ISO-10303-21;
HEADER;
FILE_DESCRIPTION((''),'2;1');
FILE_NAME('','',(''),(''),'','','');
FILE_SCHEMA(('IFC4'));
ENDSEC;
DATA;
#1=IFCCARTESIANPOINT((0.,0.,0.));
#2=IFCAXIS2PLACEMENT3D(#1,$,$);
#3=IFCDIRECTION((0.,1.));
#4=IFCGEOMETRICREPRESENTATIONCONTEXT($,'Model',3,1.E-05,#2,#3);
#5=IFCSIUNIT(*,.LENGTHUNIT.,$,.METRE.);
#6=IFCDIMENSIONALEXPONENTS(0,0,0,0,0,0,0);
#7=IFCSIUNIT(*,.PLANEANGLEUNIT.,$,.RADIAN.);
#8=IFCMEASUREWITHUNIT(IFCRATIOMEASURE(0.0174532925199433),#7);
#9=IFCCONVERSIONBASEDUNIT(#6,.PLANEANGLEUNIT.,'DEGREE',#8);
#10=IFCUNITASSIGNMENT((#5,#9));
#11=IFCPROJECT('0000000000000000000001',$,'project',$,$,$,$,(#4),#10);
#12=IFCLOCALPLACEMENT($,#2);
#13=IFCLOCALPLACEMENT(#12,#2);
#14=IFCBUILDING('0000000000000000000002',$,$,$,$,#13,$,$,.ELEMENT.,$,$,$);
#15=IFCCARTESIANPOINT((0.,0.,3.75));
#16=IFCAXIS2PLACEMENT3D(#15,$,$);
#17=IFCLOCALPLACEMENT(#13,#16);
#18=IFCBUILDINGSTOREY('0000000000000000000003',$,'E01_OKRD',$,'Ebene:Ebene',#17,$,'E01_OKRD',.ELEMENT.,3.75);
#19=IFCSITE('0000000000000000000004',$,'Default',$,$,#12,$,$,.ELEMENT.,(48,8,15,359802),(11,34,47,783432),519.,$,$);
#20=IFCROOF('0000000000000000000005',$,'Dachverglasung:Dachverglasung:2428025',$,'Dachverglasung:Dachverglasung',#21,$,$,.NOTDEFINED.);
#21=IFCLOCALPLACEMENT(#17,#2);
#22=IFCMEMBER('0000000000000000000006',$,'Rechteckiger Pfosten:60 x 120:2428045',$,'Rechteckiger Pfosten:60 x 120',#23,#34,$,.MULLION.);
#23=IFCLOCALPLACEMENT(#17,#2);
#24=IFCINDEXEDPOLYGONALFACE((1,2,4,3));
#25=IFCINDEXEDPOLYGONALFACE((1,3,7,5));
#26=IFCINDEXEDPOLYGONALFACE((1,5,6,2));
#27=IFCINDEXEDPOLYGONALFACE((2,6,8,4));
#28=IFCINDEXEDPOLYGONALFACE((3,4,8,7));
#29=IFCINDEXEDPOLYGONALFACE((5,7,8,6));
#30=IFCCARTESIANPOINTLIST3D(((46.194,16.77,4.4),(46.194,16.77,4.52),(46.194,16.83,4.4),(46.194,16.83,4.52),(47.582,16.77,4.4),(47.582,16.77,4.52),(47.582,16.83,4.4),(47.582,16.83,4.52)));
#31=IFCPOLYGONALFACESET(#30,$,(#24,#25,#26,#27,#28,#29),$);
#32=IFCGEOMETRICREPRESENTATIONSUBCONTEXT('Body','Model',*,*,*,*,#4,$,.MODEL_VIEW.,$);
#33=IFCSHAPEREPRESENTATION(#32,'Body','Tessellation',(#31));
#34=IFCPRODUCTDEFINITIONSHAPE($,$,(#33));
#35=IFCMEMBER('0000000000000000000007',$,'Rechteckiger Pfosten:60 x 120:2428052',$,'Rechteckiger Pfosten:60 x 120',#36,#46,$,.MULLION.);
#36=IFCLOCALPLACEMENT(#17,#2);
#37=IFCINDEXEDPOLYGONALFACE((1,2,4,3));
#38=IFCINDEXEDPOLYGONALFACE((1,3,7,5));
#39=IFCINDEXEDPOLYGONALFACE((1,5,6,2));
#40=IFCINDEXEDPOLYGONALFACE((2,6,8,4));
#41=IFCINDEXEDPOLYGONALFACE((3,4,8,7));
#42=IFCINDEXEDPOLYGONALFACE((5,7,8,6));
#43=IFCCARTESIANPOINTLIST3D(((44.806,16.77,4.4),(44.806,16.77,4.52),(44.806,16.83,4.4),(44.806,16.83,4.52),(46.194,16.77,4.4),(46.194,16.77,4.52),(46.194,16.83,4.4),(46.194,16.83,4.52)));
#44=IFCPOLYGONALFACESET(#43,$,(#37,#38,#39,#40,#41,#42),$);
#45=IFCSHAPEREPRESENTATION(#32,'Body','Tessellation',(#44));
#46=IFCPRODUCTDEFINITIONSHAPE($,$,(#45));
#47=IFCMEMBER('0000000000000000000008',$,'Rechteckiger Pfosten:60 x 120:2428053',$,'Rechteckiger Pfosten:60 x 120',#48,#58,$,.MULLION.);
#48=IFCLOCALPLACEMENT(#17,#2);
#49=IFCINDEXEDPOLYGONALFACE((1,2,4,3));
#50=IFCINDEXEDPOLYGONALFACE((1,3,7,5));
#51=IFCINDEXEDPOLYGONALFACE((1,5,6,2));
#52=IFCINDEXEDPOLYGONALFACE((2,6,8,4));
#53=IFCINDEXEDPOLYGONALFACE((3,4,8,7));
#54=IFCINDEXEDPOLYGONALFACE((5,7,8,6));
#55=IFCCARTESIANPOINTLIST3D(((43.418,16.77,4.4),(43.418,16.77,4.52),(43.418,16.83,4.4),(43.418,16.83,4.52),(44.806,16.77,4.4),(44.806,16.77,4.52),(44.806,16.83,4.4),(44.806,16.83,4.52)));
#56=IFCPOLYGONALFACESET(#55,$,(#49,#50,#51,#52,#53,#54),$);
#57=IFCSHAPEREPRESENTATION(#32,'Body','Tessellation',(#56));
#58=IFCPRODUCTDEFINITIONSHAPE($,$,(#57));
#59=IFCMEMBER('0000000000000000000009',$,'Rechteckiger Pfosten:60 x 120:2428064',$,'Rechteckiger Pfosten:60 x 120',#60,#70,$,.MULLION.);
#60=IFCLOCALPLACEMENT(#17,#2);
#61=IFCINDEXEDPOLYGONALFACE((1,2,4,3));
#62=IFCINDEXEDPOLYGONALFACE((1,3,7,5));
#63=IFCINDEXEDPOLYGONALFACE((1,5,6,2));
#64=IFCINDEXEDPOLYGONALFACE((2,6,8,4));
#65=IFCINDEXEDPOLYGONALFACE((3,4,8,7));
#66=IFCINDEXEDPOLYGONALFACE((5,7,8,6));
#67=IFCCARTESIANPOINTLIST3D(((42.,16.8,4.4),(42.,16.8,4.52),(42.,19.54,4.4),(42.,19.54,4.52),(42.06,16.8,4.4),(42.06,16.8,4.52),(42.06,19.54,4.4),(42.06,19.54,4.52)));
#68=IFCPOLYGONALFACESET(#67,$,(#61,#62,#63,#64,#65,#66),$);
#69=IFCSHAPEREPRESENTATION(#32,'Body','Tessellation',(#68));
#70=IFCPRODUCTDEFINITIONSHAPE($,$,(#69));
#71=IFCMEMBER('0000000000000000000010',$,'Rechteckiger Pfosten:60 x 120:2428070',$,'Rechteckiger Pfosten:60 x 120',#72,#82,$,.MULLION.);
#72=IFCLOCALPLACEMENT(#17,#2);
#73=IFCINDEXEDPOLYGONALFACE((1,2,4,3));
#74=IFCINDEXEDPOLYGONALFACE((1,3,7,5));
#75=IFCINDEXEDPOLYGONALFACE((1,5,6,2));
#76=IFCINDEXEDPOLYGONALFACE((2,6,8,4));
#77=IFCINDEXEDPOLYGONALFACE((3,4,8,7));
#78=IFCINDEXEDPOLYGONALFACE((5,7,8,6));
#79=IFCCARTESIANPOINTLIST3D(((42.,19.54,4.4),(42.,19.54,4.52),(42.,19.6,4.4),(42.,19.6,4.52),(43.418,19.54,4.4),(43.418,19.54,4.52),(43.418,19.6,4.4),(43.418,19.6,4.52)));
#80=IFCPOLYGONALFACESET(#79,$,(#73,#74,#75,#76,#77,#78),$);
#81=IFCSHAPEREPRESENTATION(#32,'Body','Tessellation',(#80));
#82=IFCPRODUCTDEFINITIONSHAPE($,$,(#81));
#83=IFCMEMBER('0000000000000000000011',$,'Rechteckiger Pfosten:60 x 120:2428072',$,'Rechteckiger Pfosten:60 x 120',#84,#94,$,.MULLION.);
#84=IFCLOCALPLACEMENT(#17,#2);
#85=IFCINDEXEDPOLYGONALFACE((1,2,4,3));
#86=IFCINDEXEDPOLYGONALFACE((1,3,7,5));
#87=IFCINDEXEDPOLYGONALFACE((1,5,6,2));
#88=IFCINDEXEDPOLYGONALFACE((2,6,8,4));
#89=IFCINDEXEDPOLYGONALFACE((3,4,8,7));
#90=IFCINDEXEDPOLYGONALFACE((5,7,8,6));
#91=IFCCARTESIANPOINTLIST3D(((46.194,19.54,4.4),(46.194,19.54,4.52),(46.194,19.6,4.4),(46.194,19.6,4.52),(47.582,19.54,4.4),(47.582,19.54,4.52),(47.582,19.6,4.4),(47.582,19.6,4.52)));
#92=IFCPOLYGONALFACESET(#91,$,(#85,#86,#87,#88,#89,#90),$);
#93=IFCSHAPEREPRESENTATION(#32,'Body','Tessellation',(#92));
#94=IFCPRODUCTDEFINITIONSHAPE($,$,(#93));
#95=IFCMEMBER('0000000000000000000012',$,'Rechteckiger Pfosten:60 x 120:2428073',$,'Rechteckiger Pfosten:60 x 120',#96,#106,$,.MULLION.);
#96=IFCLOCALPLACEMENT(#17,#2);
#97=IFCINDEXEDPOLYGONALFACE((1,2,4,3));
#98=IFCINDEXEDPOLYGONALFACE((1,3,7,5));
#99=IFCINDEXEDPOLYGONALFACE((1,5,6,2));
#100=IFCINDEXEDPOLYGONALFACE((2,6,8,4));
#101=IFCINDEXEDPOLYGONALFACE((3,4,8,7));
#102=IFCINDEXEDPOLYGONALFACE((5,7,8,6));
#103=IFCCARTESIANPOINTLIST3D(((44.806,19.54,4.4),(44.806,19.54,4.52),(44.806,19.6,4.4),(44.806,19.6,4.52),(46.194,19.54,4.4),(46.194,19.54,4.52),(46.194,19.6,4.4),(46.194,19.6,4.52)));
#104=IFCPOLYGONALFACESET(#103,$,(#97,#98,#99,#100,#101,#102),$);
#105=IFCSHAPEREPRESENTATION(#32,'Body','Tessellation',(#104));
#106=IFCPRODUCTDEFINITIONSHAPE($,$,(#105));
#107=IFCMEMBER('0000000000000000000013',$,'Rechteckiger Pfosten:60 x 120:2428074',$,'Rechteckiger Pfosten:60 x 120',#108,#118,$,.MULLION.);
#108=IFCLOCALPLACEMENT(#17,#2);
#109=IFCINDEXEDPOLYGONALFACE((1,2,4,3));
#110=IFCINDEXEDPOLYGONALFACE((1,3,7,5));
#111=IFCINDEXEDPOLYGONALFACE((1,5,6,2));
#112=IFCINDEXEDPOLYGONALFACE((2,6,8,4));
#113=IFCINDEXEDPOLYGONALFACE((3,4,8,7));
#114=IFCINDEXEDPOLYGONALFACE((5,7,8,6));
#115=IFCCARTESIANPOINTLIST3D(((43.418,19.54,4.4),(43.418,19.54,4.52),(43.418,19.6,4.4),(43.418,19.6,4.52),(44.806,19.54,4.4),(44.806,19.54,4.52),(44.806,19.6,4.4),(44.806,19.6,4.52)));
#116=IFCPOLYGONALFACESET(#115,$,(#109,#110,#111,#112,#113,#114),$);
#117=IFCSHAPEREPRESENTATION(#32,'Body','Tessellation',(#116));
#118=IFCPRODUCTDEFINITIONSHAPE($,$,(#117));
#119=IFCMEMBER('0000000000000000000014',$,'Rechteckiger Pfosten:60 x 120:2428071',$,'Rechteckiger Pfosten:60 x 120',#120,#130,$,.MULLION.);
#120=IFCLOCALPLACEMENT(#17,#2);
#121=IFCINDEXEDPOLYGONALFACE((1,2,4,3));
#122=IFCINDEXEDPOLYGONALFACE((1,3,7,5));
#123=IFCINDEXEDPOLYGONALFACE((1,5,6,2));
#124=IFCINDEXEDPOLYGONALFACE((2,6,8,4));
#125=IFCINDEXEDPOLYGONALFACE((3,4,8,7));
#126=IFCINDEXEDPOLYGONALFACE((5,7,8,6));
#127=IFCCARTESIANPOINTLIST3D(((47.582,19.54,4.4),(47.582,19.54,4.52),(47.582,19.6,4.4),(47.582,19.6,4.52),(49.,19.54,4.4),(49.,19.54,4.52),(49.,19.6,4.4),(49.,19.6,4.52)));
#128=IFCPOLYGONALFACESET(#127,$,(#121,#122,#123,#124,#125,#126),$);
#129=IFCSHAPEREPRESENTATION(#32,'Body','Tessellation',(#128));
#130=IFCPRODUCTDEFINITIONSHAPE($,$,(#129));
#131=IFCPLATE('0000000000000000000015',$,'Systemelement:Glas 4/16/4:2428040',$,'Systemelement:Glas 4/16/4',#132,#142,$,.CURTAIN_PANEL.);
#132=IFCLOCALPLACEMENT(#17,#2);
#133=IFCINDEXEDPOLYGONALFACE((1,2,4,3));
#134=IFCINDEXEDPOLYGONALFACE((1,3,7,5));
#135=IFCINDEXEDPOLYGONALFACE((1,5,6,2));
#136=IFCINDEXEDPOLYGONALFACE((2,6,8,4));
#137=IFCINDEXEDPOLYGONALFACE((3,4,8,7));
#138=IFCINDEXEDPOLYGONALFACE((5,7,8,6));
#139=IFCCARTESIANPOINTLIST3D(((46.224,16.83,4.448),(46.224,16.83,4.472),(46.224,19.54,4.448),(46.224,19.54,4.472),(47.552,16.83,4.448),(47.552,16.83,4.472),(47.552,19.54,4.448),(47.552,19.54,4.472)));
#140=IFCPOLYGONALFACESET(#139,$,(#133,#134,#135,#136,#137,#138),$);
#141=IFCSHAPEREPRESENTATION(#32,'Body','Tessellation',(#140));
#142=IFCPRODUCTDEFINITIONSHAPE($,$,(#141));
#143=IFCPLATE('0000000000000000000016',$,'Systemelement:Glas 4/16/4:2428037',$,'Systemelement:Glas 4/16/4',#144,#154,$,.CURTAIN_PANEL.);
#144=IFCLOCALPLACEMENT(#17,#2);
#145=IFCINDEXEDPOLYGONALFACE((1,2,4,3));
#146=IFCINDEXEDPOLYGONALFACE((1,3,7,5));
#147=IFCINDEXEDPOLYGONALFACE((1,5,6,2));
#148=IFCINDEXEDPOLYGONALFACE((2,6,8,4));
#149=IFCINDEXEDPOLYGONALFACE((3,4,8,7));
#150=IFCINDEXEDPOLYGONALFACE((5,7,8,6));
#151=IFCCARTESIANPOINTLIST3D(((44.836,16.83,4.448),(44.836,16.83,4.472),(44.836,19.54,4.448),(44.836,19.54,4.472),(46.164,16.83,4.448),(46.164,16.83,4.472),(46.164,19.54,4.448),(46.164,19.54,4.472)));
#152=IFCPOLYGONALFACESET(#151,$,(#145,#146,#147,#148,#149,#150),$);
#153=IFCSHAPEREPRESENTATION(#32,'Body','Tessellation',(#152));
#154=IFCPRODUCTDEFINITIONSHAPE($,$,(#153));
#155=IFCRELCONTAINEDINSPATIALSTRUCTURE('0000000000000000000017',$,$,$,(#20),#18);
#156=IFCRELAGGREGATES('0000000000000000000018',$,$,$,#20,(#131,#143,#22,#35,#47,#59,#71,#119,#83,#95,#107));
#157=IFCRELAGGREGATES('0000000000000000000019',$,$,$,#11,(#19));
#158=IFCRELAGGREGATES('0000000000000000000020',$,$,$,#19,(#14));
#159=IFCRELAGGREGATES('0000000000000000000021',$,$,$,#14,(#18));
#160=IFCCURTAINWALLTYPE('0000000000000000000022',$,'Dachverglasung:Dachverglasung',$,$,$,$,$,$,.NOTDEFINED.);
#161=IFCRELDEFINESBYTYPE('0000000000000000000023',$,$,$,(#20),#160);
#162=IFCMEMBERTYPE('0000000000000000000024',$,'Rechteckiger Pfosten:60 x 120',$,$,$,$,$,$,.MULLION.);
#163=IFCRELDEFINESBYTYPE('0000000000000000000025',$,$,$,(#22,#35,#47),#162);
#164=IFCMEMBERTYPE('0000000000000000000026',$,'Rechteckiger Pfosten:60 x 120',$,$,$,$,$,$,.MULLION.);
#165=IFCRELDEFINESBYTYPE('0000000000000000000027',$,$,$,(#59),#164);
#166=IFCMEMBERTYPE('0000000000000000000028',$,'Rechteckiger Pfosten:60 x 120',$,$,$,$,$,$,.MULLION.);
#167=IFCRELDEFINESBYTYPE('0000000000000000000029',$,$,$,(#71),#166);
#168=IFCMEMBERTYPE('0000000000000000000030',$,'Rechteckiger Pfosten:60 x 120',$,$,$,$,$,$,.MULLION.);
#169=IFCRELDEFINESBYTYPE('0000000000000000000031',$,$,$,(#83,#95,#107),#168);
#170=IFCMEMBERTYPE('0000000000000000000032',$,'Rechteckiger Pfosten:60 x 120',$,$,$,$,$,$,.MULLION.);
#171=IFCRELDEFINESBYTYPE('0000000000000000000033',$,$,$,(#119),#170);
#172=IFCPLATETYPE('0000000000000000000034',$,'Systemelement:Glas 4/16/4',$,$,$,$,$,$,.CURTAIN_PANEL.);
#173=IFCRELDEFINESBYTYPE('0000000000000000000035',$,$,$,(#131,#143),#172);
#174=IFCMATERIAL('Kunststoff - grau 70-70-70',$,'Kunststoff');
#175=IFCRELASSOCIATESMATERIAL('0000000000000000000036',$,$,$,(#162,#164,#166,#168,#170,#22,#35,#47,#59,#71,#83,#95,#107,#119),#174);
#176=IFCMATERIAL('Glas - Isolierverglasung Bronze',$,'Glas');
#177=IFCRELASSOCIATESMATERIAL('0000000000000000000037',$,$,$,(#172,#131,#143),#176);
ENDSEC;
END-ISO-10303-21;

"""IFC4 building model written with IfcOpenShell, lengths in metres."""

from ifc_helpers import new_model, entity, si_unit, converted_unit, direction, frame, frame_2d, origin, origin_2d_with_axis, place, context, subcontext, project, spatial, rectangle, extrude, shape, source, transform, mapped, material, material_profile, profile_set, profile_usage, type_object, type_shapes, element, aggregate, save


model = new_model("IFC4")

# Units and contexts
model_context = context("Model", 3, precision=1e-05, world=origin(), true_north=direction((0.0, 1.0)))
body_context = subcontext(model_context, "Body", "Model", "MODEL_VIEW")
footprint_context = subcontext(model_context, "FootPrint", "Model", "MODEL_VIEW")
ifc_project = project(units=[si_unit("LENGTHUNIT", "METRE"), converted_unit("PLANEANGLEUNIT", "DEGREE", entity("IfcRatioMeasure", 0.0174532925199433), si_unit("PLANEANGLEUNIT", "RADIAN"), dimensions=[0, 0, 0, 0, 0, 0, 0])], contexts=[model_context])

# Site, building, storey
site_placement = place(None, frame((0.0, 0.0, 0.0)))
site = spatial("IfcSite", under=ifc_project, at=site_placement, Name="Default", CompositionType="ELEMENT", RefLatitude=(48, 8, 15, 359802), RefLongitude=(11, 34, 47, 783432), RefElevation=519.0)
building_placement = place(site_placement, origin())
building = spatial("IfcBuilding", under=site, at=building_placement, CompositionType="ELEMENT")
storey_placement = place(building_placement, frame((0.0, 0.0, 3.75)))
storey = spatial("IfcBuildingStorey", under=building, at=storey_placement, Name="E01_OKRD", ObjectType="Ebene:Ebene", LongName="E01_OKRD", CompositionType="ELEMENT", Elevation=3.75)

# Roof, members, plates
curtain_wall_type = type_object("IfcCurtainWallType", Name="Dachverglasung:Dachverglasung", PredefinedType="NOTDEFINED")
roof_placement = place(storey_placement, frame((0.0, 0.0, -3.75)))
roof = element("IfcRoof", 1, at=roof_placement, inside=storey, type_object=curtain_wall_type, Name="Dachverglasung:Dachverglasung:2428025", ObjectType="Dachverglasung:Dachverglasung", PredefinedType="NOTDEFINED")
ifc_material_1 = material(Name="Kunststoff - grau 70-70-70", Category="Kunststoff")
ifc_material_profile_1 = material_profile(ifc_material_1, rectangle(XDim=0.06, YDim=0.12, at=frame_2d((0.0, 0.0), x_axis=(1.0, 0.0))), Name="60 x 120")
ifc_profile_set_1 = profile_set([ifc_material_profile_1], Name="60 x 120")
ifc_profile_usage_1 = profile_usage(ifc_profile_set_1)
member_type_1 = type_object("IfcMemberType", Name="Rechteckiger Pfosten:60 x 120", PredefinedType="MULLION", material=ifc_profile_set_1)
shared_shape_1 = source(origin(), body_context, "Body", "SweptSolid", [
    extrude(rectangle(XDim=0.06, YDim=0.12, at=frame_2d((0.0, 0.0), x_axis=(1.0, 0.0))), frame((0.0, 0.0, -1.388), z_axis=(0.0, 0.0, 1.0), x_axis=(-1.0, 0.0, 0.0)), (0.0, 0.0, 1.0), 1.388),
])
type_shapes(member_type_1, [shared_shape_1])
member_1_placement = place(storey_placement, frame((46.194, 16.8, 4.46), z_axis=(-1.0, 0.0, 0.0), x_axis=(0.0, 1.0, 0.0)))
member_1 = element("IfcMember", 2, at=member_1_placement, type_object=member_type_1, material=ifc_profile_usage_1, Name="Rechteckiger Pfosten:60 x 120:2428045", ObjectType="Rechteckiger Pfosten:60 x 120", PredefinedType="MULLION", context=body_context, shape_type="MappedRepresentation", body=[
    mapped(shared_shape_1, transform((0.0, 0.0, 0.0), scale=1.0)),
])
ifc_profile_usage_2 = profile_usage(ifc_profile_set_1)
member_2_placement = place(storey_placement, frame((44.806, 16.8, 4.46), z_axis=(-1.0, 0.0, 0.0), x_axis=(0.0, 1.0, 0.0)))
member_2 = element("IfcMember", 3, at=member_2_placement, type_object=member_type_1, material=ifc_profile_usage_2, Name="Rechteckiger Pfosten:60 x 120:2428052", ObjectType="Rechteckiger Pfosten:60 x 120", PredefinedType="MULLION", context=body_context, shape_type="MappedRepresentation", body=[
    mapped(shared_shape_1, transform((0.0, 0.0, 0.0), scale=1.0)),
])
ifc_profile_usage_3 = profile_usage(ifc_profile_set_1)
member_3_placement = place(storey_placement, frame((43.418, 16.8, 4.46), z_axis=(-1.0, 0.0, 0.0), x_axis=(0.0, 1.0, 0.0)))
member_3 = element("IfcMember", 4, at=member_3_placement, type_object=member_type_1, material=ifc_profile_usage_3, Name="Rechteckiger Pfosten:60 x 120:2428053", ObjectType="Rechteckiger Pfosten:60 x 120", PredefinedType="MULLION", context=body_context, shape_type="MappedRepresentation", body=[
    mapped(shared_shape_1, transform((0.0, 0.0, 0.0), scale=1.0)),
])
ifc_profile_usage_4 = profile_usage(ifc_profile_set_1)
member_type_2 = type_object("IfcMemberType", Name="Rechteckiger Pfosten:60 x 120", PredefinedType="MULLION", material=ifc_profile_set_1)
shared_shape_2 = source(origin(), body_context, "Body", "SweptSolid", [
    extrude(rectangle(XDim=0.06, YDim=0.12, at=origin_2d_with_axis()), frame((-0.03, 0.0, -2.74), z_axis=(0.0, 0.0, 1.0), x_axis=(-1.0, 0.0, 0.0)), (0.0, 0.0, 1.0), 2.74),
])
type_shapes(member_type_2, [shared_shape_2])
member_4_placement = place(storey_placement, frame((42.0, 16.8, 4.46), z_axis=(0.0, -1.0, 0.0), x_axis=(-1.0, 0.0, 0.0)))
member_4 = element("IfcMember", 5, at=member_4_placement, type_object=member_type_2, material=ifc_profile_usage_4, Name="Rechteckiger Pfosten:60 x 120:2428064", ObjectType="Rechteckiger Pfosten:60 x 120", PredefinedType="MULLION", context=body_context, shape_type="MappedRepresentation", body=[
    mapped(shared_shape_2, transform((0.0, 0.0, 0.0), scale=1.0)),
])
ifc_profile_usage_5 = profile_usage(ifc_profile_set_1)
member_type_3 = type_object("IfcMemberType", Name="Rechteckiger Pfosten:60 x 120", PredefinedType="MULLION", material=ifc_profile_set_1)
shared_shape_3 = source(origin(), body_context, "Body", "SweptSolid", [
    extrude(rectangle(XDim=0.06, YDim=0.12, at=origin_2d_with_axis()), frame((-0.03, 0.0, -1.418), z_axis=(0.0, 0.0, 1.0), x_axis=(-1.0, 0.0, 0.0)), (0.0, 0.0, 1.0), 1.418),
])
type_shapes(member_type_3, [shared_shape_3])
member_5_placement = place(storey_placement, frame((42.0, 19.6, 4.46), z_axis=(-1.0, 0.0, 0.0), x_axis=(0.0, 1.0, 0.0)))
member_5 = element("IfcMember", 6, at=member_5_placement, type_object=member_type_3, material=ifc_profile_usage_5, Name="Rechteckiger Pfosten:60 x 120:2428070", ObjectType="Rechteckiger Pfosten:60 x 120", PredefinedType="MULLION", context=body_context, shape_type="MappedRepresentation", body=[
    mapped(shared_shape_3, transform((0.0, 0.0, 0.0), scale=1.0)),
])
ifc_profile_usage_6 = profile_usage(ifc_profile_set_1)
member_type_4 = type_object("IfcMemberType", Name="Rechteckiger Pfosten:60 x 120", PredefinedType="MULLION", material=ifc_profile_set_1)
shared_shape_4 = source(origin(), body_context, "Body", "SweptSolid", [
    extrude(rectangle(XDim=0.06, YDim=0.12, at=origin_2d_with_axis()), frame((-0.03, 0.0, -1.388), z_axis=(0.0, 0.0, 1.0), x_axis=(-1.0, 0.0, 0.0)), (0.0, 0.0, 1.0), 1.388),
])
type_shapes(member_type_4, [shared_shape_4])
member_6_placement = place(storey_placement, frame((46.194, 19.6, 4.46), z_axis=(-1.0, 0.0, 0.0), x_axis=(0.0, 1.0, 0.0)))
member_6 = element("IfcMember", 7, at=member_6_placement, type_object=member_type_4, material=ifc_profile_usage_6, Name="Rechteckiger Pfosten:60 x 120:2428072", ObjectType="Rechteckiger Pfosten:60 x 120", PredefinedType="MULLION", context=body_context, shape_type="MappedRepresentation", body=[
    mapped(shared_shape_4, transform((0.0, 0.0, 0.0), scale=1.0)),
])
ifc_profile_usage_7 = profile_usage(ifc_profile_set_1)
member_7_placement = place(storey_placement, frame((44.806, 19.6, 4.46), z_axis=(-1.0, 0.0, 0.0), x_axis=(0.0, 1.0, 0.0)))
member_7 = element("IfcMember", 8, at=member_7_placement, type_object=member_type_4, material=ifc_profile_usage_7, Name="Rechteckiger Pfosten:60 x 120:2428073", ObjectType="Rechteckiger Pfosten:60 x 120", PredefinedType="MULLION", context=body_context, shape_type="MappedRepresentation", body=[
    mapped(shared_shape_4, transform((0.0, 0.0, 0.0), scale=1.0)),
])
ifc_profile_usage_8 = profile_usage(ifc_profile_set_1)
member_8_placement = place(storey_placement, frame((43.418, 19.6, 4.46), z_axis=(-1.0, 0.0, 0.0), x_axis=(0.0, 1.0, 0.0)))
member_8 = element("IfcMember", 9, at=member_8_placement, type_object=member_type_4, material=ifc_profile_usage_8, Name="Rechteckiger Pfosten:60 x 120:2428074", ObjectType="Rechteckiger Pfosten:60 x 120", PredefinedType="MULLION", context=body_context, shape_type="MappedRepresentation", body=[
    mapped(shared_shape_4, transform((0.0, 0.0, 0.0), scale=1.0)),
])
ifc_profile_usage_9 = profile_usage(ifc_profile_set_1)
member_type_5 = type_object("IfcMemberType", Name="Rechteckiger Pfosten:60 x 120", PredefinedType="MULLION", material=ifc_profile_set_1)
shared_shape_5 = source(origin(), body_context, "Body", "SweptSolid", [
    extrude(rectangle(XDim=0.06, YDim=0.12, at=origin_2d_with_axis()), frame((-0.03, 0.0, -1.418), z_axis=(0.0, 0.0, 1.0), x_axis=(-1.0, 0.0, 0.0)), (0.0, 0.0, 1.0), 1.418),
])
type_shapes(member_type_5, [shared_shape_5])
member_9_placement = place(storey_placement, frame((47.582, 19.6, 4.46), z_axis=(-1.0, 0.0, 0.0), x_axis=(0.0, 1.0, 0.0)))
member_9 = element("IfcMember", 10, at=member_9_placement, type_object=member_type_5, material=ifc_profile_usage_9, Name="Rechteckiger Pfosten:60 x 120:2428071", ObjectType="Rechteckiger Pfosten:60 x 120", PredefinedType="MULLION", context=body_context, shape_type="MappedRepresentation", body=[
    mapped(shared_shape_5, transform((0.0, 0.0, 0.0), scale=1.0)),
])
ifc_material_2 = material(Name="Glas - Isolierverglasung Bronze", Category="Glas")
plate_type = type_object("IfcPlateType", Name="Systemelement:Glas 4/16/4", PredefinedType="CURTAIN_PANEL", material=ifc_material_2)
shared_shape_6 = source(origin(), body_context, "Body", "SweptSolid", [
    extrude(rectangle(XDim=0.024, YDim=2.71, at=origin_2d_with_axis()), frame((0.0, 0.0, 0.0), z_axis=(0.0, 0.0, 1.0), x_axis=(0.0, 1.0, 0.0)), (0.0, 0.0, 1.0), 1.328),
])
cartesian_point = entity("IfcCartesianPoint", [1.355, -0.012])
shared_shape_7 = source(origin(), footprint_context, "FootPrint", "Curve2D", [
    entity("IfcPolyline", [cartesian_point, entity("IfcCartesianPoint", [1.355, 0.012]), entity("IfcCartesianPoint", [-1.355, 0.012]), entity("IfcCartesianPoint", [-1.355, -0.012]), cartesian_point]),
])
type_shapes(plate_type, [shared_shape_6, shared_shape_7])
plate_1_placement = place(roof_placement, frame((47.552, 18.185, 8.21), z_axis=(-1.0, 0.0, 0.0), x_axis=(0.0, 1.0, 0.0)))
plate_1 = element("IfcPlate", 11, at=plate_1_placement, type_object=plate_type, material=ifc_material_2, Name="Systemelement:Glas 4/16/4:2428040", ObjectType="Systemelement:Glas 4/16/4", PredefinedType="CURTAIN_PANEL", shapes=[
    shape(body_context, "Body", "MappedRepresentation", [mapped(shared_shape_6, transform((0.0, 0.0, 0.0), scale=1.0))]),
    shape(body_context, "Body", "MappedRepresentation", [mapped(shared_shape_7, transform((0.0, 0.0, 0.0), scale=1.0))]),
])
plate_2_placement = place(roof_placement, frame((46.164, 18.185, 8.21), z_axis=(-1.0, 0.0, 0.0), x_axis=(0.0, 1.0, 0.0)))
plate_2 = element("IfcPlate", 12, at=plate_2_placement, type_object=plate_type, material=ifc_material_2, Name="Systemelement:Glas 4/16/4:2428037", ObjectType="Systemelement:Glas 4/16/4", PredefinedType="CURTAIN_PANEL", shapes=[
    shape(body_context, "Body", "MappedRepresentation", [mapped(shared_shape_6, transform((0.0, 0.0, 0.0), scale=1.0))]),
    shape(body_context, "Body", "MappedRepresentation", [mapped(shared_shape_7, transform((0.0, 0.0, 0.0), scale=1.0))]),
])
aggregate(roof, [plate_1, plate_2, member_1, member_2, member_3, member_4, member_5, member_9, member_6, member_7, member_8])

save(model, "model.ifc")
